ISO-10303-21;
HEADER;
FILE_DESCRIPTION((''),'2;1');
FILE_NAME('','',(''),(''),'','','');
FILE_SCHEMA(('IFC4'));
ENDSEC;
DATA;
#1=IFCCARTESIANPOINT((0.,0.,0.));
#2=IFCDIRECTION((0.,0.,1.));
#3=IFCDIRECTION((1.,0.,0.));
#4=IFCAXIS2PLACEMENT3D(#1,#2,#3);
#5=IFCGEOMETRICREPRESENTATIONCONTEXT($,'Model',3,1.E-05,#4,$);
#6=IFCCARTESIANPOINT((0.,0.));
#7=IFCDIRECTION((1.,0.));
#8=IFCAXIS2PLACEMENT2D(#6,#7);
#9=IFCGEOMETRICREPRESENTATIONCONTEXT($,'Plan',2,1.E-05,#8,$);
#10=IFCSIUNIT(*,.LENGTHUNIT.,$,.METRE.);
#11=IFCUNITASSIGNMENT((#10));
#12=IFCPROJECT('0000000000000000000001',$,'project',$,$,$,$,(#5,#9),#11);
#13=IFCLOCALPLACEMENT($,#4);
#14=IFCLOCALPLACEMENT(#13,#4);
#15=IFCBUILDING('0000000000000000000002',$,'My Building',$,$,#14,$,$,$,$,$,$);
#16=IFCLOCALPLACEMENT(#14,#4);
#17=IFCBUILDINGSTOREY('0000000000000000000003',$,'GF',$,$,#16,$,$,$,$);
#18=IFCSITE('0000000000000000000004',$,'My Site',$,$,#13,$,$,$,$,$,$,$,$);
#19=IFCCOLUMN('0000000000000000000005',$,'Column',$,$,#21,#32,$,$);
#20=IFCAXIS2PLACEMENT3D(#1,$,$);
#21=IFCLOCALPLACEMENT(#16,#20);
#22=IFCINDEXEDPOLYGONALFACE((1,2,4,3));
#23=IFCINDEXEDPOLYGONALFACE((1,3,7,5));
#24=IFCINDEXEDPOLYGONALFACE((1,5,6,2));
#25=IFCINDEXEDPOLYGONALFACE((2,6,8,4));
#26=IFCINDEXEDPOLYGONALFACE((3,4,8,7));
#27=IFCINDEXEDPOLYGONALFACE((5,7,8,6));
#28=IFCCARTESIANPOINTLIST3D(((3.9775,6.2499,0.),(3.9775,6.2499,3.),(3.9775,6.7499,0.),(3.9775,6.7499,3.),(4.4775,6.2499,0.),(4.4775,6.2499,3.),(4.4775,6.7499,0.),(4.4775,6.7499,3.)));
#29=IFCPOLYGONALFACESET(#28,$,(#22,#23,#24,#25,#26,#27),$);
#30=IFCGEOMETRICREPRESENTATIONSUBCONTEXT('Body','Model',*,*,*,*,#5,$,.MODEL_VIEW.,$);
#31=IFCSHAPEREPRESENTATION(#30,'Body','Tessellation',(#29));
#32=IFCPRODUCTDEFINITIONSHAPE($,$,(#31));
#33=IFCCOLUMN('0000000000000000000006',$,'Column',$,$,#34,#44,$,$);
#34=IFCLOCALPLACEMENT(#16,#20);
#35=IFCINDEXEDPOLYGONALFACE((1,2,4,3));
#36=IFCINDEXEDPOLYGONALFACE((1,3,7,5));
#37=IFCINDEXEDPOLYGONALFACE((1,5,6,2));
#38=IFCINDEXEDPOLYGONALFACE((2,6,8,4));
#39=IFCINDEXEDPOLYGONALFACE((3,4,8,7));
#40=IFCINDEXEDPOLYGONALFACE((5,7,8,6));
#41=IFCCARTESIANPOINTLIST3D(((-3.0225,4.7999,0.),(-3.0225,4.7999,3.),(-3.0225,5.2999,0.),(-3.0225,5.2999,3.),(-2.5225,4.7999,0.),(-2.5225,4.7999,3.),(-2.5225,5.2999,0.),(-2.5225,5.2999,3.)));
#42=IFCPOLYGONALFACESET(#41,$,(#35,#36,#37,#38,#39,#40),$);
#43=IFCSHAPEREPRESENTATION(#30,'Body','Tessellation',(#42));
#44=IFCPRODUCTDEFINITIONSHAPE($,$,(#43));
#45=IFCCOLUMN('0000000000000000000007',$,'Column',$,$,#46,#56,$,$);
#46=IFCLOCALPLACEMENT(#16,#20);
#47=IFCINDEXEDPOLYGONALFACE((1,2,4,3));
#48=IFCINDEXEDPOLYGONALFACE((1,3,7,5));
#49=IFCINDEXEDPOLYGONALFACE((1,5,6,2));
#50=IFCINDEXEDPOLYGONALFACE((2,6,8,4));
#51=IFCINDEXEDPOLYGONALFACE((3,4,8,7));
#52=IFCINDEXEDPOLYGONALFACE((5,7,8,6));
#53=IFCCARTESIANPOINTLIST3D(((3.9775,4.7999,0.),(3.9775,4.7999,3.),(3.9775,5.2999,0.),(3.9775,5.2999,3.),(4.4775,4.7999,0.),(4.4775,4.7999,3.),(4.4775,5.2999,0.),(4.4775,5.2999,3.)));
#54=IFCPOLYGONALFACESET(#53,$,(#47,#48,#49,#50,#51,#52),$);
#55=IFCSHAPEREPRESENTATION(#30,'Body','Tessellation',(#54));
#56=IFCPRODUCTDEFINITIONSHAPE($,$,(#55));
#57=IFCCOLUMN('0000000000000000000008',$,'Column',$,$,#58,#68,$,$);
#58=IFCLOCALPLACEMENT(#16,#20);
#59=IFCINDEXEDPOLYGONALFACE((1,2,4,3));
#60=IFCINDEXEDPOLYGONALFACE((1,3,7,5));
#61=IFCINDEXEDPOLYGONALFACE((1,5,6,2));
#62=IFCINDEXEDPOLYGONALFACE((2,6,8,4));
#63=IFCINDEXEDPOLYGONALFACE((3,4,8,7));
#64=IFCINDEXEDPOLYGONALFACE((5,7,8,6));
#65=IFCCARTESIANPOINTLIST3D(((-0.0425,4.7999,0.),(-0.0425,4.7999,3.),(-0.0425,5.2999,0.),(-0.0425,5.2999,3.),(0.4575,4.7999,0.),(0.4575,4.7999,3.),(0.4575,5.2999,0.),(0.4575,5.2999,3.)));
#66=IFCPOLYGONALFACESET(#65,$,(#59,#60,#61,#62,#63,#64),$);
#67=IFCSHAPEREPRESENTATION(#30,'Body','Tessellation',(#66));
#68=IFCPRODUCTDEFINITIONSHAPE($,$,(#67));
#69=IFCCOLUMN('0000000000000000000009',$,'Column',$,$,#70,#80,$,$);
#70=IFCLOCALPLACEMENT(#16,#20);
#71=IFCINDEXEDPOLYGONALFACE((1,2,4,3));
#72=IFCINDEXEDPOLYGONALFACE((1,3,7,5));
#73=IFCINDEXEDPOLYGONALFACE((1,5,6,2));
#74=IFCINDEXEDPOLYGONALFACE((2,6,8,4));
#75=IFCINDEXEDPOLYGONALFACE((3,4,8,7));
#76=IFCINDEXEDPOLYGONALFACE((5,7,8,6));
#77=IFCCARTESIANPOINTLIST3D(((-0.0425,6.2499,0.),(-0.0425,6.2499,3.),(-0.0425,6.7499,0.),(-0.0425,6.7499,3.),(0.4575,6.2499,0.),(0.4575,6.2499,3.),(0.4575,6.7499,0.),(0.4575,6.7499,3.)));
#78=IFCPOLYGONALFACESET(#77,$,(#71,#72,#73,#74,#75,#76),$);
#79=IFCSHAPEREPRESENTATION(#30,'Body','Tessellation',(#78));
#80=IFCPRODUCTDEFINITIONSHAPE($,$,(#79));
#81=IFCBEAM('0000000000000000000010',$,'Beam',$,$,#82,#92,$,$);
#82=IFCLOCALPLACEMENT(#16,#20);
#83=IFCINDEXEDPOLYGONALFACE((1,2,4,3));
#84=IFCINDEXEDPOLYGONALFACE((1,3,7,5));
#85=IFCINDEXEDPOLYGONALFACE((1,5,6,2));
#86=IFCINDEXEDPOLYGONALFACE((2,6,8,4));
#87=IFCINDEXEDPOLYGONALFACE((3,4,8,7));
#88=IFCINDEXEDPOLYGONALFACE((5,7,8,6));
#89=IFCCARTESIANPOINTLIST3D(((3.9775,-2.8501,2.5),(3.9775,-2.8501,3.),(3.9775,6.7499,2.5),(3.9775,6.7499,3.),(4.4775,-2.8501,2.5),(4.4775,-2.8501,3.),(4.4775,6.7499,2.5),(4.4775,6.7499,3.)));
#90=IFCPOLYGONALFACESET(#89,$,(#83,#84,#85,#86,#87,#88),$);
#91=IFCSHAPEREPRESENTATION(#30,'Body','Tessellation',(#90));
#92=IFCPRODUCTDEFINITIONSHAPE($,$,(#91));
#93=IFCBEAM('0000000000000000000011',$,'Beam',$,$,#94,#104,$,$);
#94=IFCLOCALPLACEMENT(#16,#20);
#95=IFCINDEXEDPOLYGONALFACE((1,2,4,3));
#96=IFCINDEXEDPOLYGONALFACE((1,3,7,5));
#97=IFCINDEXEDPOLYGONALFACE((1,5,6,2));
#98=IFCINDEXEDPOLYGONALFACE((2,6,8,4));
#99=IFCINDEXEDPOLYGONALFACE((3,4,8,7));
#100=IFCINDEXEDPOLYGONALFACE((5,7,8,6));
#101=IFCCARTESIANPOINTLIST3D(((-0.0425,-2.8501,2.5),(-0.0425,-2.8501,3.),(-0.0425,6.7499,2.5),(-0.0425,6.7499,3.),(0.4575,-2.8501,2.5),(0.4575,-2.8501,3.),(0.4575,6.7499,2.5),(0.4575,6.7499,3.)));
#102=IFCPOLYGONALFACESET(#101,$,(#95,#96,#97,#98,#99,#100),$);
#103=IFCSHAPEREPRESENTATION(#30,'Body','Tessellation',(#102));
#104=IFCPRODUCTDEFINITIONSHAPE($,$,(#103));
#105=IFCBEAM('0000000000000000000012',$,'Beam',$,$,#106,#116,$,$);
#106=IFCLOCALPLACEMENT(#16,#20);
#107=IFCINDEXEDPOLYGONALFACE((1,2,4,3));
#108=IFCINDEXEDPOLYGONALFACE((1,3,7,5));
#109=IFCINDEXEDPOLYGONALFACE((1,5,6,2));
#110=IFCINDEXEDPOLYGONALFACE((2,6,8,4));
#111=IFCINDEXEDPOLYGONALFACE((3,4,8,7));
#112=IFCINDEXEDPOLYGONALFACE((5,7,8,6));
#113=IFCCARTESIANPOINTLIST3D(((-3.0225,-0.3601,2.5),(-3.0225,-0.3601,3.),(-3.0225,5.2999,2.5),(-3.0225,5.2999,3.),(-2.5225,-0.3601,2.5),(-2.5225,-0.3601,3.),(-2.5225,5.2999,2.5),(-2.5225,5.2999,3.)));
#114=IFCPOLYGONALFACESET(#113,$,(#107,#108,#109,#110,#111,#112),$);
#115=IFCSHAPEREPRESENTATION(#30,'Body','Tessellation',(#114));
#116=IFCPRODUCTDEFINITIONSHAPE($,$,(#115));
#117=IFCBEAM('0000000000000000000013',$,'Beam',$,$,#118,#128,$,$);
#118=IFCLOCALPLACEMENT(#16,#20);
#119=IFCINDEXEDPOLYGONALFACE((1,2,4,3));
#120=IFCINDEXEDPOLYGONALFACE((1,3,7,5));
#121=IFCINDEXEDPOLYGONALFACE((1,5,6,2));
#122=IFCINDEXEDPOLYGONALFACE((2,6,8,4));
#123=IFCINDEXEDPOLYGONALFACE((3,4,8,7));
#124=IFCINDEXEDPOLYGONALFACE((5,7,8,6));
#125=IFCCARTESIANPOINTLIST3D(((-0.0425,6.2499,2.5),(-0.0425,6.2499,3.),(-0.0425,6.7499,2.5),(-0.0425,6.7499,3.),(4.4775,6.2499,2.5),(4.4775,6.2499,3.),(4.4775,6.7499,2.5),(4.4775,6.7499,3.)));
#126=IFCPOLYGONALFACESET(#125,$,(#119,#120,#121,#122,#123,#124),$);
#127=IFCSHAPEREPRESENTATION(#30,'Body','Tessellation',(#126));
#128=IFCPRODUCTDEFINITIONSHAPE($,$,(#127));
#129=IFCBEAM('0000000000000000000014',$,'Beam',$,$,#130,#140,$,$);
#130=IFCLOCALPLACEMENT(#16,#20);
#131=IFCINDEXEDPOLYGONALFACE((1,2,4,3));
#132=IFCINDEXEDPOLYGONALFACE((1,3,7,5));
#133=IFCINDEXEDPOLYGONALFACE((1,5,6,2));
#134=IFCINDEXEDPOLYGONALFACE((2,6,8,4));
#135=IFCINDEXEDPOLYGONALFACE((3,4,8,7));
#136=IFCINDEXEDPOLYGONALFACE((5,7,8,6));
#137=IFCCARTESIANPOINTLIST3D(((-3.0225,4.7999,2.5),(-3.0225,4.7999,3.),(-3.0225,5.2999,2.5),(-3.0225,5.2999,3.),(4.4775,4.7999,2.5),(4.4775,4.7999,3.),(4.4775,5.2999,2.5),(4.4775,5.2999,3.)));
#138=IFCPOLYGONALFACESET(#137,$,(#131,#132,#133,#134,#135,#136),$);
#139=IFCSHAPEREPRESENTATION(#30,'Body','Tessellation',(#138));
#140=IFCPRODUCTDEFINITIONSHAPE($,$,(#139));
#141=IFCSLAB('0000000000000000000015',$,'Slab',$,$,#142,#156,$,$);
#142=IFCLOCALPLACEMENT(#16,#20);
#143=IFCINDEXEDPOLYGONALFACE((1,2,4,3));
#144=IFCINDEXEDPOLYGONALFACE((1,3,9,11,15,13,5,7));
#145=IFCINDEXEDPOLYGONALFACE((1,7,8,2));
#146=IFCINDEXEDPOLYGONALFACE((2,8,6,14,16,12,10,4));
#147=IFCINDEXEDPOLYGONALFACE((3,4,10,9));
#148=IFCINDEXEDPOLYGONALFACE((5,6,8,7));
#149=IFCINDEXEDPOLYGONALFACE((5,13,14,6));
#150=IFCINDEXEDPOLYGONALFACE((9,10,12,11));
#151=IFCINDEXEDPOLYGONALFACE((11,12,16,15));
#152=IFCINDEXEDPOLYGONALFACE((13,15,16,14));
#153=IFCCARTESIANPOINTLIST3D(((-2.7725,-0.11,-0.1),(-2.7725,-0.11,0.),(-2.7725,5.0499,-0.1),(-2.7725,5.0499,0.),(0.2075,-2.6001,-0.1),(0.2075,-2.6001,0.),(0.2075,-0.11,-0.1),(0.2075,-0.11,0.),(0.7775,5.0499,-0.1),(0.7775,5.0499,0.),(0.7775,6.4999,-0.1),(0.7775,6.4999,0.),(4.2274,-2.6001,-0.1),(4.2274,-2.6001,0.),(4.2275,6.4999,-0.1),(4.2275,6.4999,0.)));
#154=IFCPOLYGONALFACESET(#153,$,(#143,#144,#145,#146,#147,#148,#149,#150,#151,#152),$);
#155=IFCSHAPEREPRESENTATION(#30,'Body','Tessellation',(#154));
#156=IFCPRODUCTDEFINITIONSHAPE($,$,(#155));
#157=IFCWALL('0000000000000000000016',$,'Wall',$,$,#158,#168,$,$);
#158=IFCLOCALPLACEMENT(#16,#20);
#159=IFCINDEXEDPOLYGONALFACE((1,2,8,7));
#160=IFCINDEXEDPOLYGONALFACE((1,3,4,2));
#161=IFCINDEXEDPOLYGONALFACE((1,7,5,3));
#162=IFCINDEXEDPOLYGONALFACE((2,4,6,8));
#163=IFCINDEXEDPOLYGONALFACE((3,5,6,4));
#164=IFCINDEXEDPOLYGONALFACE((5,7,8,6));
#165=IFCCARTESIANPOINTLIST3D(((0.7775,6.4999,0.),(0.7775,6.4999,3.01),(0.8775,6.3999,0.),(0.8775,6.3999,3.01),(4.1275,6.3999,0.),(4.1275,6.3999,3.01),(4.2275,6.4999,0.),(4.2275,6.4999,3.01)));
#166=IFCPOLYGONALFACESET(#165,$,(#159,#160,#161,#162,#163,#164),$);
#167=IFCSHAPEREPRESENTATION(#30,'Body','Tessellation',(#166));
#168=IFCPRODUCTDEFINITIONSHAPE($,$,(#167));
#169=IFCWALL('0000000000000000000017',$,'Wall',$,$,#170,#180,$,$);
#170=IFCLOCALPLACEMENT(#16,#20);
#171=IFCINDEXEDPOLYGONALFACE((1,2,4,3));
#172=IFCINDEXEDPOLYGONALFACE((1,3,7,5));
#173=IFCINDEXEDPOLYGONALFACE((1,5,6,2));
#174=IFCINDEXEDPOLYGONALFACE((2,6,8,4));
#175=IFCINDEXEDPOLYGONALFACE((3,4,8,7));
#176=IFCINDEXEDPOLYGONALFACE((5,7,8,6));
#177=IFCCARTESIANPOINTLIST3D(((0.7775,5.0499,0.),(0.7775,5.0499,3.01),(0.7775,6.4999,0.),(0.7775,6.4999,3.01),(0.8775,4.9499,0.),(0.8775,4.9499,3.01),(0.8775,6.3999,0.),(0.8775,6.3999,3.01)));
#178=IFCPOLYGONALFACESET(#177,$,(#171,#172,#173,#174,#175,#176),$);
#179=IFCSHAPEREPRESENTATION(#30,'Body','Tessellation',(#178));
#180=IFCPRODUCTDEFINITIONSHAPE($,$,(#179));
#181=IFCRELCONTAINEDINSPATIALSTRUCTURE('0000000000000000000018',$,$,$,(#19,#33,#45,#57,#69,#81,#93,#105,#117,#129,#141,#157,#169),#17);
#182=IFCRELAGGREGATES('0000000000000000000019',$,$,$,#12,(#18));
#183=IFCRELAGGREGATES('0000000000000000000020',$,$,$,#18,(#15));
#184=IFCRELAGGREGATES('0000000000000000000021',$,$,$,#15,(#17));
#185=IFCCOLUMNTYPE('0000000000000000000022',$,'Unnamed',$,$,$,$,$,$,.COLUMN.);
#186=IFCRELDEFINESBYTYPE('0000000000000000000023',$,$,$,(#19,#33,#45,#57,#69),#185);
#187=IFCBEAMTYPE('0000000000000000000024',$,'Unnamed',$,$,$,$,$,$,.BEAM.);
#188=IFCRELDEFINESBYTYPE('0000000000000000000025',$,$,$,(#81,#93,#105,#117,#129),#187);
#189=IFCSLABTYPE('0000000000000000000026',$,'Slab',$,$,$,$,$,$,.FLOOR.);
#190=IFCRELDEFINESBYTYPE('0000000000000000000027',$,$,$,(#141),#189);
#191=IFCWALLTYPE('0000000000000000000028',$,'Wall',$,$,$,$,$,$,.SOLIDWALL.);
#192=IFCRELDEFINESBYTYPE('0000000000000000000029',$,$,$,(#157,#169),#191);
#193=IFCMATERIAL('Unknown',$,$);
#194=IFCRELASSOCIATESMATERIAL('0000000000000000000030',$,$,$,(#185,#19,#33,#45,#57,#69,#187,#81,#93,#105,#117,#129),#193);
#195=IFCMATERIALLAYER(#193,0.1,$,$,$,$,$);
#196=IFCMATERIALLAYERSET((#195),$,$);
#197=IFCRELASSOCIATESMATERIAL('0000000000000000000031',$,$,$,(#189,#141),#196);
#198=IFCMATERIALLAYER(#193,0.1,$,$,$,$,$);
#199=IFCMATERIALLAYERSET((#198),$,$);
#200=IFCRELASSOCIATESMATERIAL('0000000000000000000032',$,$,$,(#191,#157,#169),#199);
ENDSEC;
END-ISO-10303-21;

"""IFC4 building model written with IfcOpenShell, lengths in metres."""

from ifc_helpers import new_model, si_unit, frame, origin_with_axes, origin_2d_with_axis, place, context, subcontext, project, spatial, line, indexed_curve, rectangle, outline, extrude, material, layer, layer_set, layer_usage, material_profile, profile_set, profile_usage, type_object, element, save


model = new_model("IFC4")

# Units and contexts
model_context = context("Model", 3, precision=1e-05, world=origin_with_axes())
plan_context = context("Plan", 2, precision=1e-05, world=origin_2d_with_axis())
body_context_1 = subcontext(model_context, "Body", "Model", "MODEL_VIEW")
ifc_project = project(units=[si_unit("LENGTHUNIT", "METRE")], contexts=[model_context, plan_context])

# Site, building, storey
site_placement = place(None, origin_with_axes())
site = spatial("IfcSite", under=ifc_project, at=site_placement, Name="My Site")
building_placement = place(site_placement, origin_with_axes())
building = spatial("IfcBuilding", under=site, at=building_placement, Name="My Building")
storey_placement = place(building_placement, origin_with_axes())
storey = spatial("IfcBuildingStorey", under=building, at=storey_placement, Name="GF")

# Columns
ifc_material_1 = material(Name="Unknown")
ifc_material_profile_1 = material_profile(ifc_material_1, rectangle(XDim=0.5, YDim=0.5))
ifc_profile_set_1 = profile_set([ifc_material_profile_1])
ifc_profile_usage_1 = profile_usage(ifc_profile_set_1, cardinal=5)
column_type = type_object("IfcColumnType", Name="Unnamed", PredefinedType="COLUMN", material=ifc_profile_set_1)
column_1_placement = place(storey_placement, frame((4.2275, 6.4999, 0.0), z_axis=(0.0, 0.0, 1.0), x_axis=(1.0, 0.0, 0.0)))
element("IfcColumn", 1, at=column_1_placement, inside=storey, type_object=column_type, material=ifc_profile_usage_1, Name="Column", context=body_context_1, shape_type="SweptSolid", body=[
    extrude(rectangle(XDim=0.5, YDim=0.5), origin_with_axes(), (0.0, 0.0, 1.0), 3.0),
])
ifc_profile_usage_2 = profile_usage(ifc_profile_set_1, cardinal=5)
column_2_placement = place(storey_placement, frame((-2.7725, 5.0499, 0.0), z_axis=(0.0, 0.0, 1.0), x_axis=(1.0, 0.0, 0.0)))
element("IfcColumn", 2, at=column_2_placement, inside=storey, type_object=column_type, material=ifc_profile_usage_2, Name="Column", context=body_context_1, shape_type="SweptSolid", body=[
    extrude(rectangle(XDim=0.5, YDim=0.5), origin_with_axes(), (0.0, 0.0, 1.0), 3.0),
])
ifc_profile_usage_3 = profile_usage(ifc_profile_set_1, cardinal=5)
column_3_placement = place(storey_placement, frame((4.2275, 5.0499, 0.0), z_axis=(0.0, 0.0, 1.0), x_axis=(1.0, 0.0, 0.0)))
element("IfcColumn", 3, at=column_3_placement, inside=storey, type_object=column_type, material=ifc_profile_usage_3, Name="Column", context=body_context_1, shape_type="SweptSolid", body=[
    extrude(rectangle(XDim=0.5, YDim=0.5), origin_with_axes(), (0.0, 0.0, 1.0), 3.0),
])
ifc_profile_usage_4 = profile_usage(ifc_profile_set_1, cardinal=5)
column_4_placement = place(storey_placement, frame((0.2075, 5.0499, 0.0), z_axis=(0.0, 0.0, 1.0), x_axis=(1.0, 0.0, 0.0)))
element("IfcColumn", 4, at=column_4_placement, inside=storey, type_object=column_type, material=ifc_profile_usage_4, Name="Column", context=body_context_1, shape_type="SweptSolid", body=[
    extrude(rectangle(XDim=0.5, YDim=0.5), origin_with_axes(), (0.0, 0.0, 1.0), 3.0),
])
ifc_profile_usage_5 = profile_usage(ifc_profile_set_1, cardinal=5)
column_5_placement = place(storey_placement, frame((0.2075, 6.4999, 0.0), z_axis=(0.0, 0.0, 1.0), x_axis=(1.0, 0.0, 0.0)))
element("IfcColumn", 5, at=column_5_placement, inside=storey, type_object=column_type, material=ifc_profile_usage_5, Name="Column", context=body_context_1, shape_type="SweptSolid", body=[
    extrude(rectangle(XDim=0.5, YDim=0.5), origin_with_axes(), (0.0, 0.0, 1.0), 3.0),
])

# Beams
ifc_material_profile_2 = material_profile(ifc_material_1, rectangle(XDim=0.5, YDim=0.5))
ifc_profile_set_2 = profile_set([ifc_material_profile_2])
ifc_profile_usage_6 = profile_usage(ifc_profile_set_2, cardinal=7)
beam_type = type_object("IfcBeamType", Name="Unnamed", PredefinedType="BEAM", material=ifc_profile_set_2)
beam_1_placement = place(storey_placement, frame((4.4775, 6.7499, 3.0), z_axis=(0.0, -1.0, 0.0), x_axis=(1.0, 0.0, 0.0)))
element("IfcBeam", 6, at=beam_1_placement, inside=storey, type_object=beam_type, material=ifc_profile_usage_6, Name="Beam", context=body_context_1, shape_type="SweptSolid", body=[
    extrude(rectangle(XDim=0.5, YDim=0.5), frame((-0.25, -0.25, 0.0), z_axis=(0.0, 0.0, 1.0), x_axis=(1.0, 0.0, 0.0)), (0.0, 0.0, 1.0), 9.6),
])
ifc_profile_usage_7 = profile_usage(ifc_profile_set_2, cardinal=7)
beam_2_placement = place(storey_placement, frame((0.4575, 6.7499, 3.0), z_axis=(0.0, -1.0, 0.0), x_axis=(1.0, 0.0, 0.0)))
element("IfcBeam", 7, at=beam_2_placement, inside=storey, type_object=beam_type, material=ifc_profile_usage_7, Name="Beam", context=body_context_1, shape_type="SweptSolid", body=[
    extrude(rectangle(XDim=0.5, YDim=0.5), frame((-0.25, -0.25, 0.0), z_axis=(0.0, 0.0, 1.0), x_axis=(1.0, 0.0, 0.0)), (0.0, 0.0, 1.0), 9.6),
])
ifc_profile_usage_8 = profile_usage(ifc_profile_set_2, cardinal=7)
beam_3_placement = place(storey_placement, frame((-2.5225, 5.2999, 3.0), z_axis=(0.0, -1.0, 0.0), x_axis=(1.0, 0.0, 0.0)))
element("IfcBeam", 8, at=beam_3_placement, inside=storey, type_object=beam_type, material=ifc_profile_usage_8, Name="Beam", context=body_context_1, shape_type="SweptSolid", body=[
    extrude(rectangle(XDim=0.5, YDim=0.5), frame((-0.25, -0.25, 0.0), z_axis=(0.0, 0.0, 1.0), x_axis=(1.0, 0.0, 0.0)), (0.0, 0.0, 1.0), 5.66),
])
ifc_profile_usage_9 = profile_usage(ifc_profile_set_2, cardinal=7)
beam_4_placement = place(storey_placement, frame((4.4775, 6.2499, 3.0), z_axis=(-1.0, 0.0, 0.0), x_axis=(0.0, -1.0, 0.0)))
element("IfcBeam", 9, at=beam_4_placement, inside=storey, type_object=beam_type, material=ifc_profile_usage_9, Name="Beam", context=body_context_1, shape_type="SweptSolid", body=[
    extrude(rectangle(XDim=0.5, YDim=0.5), frame((-0.25, -0.25, 0.0), z_axis=(0.0, 0.0, 1.0), x_axis=(1.0, 0.0, 0.0)), (0.0, 0.0, 1.0), 4.52),
])
ifc_profile_usage_10 = profile_usage(ifc_profile_set_2, cardinal=7)
beam_5_placement = place(storey_placement, frame((4.4775, 4.7999, 3.0), z_axis=(-1.0, 0.0, 0.0), x_axis=(0.0, -1.0, 0.0)))
element("IfcBeam", 10, at=beam_5_placement, inside=storey, type_object=beam_type, material=ifc_profile_usage_10, Name="Beam", context=body_context_1, shape_type="SweptSolid", body=[
    extrude(rectangle(XDim=0.5, YDim=0.5), frame((-0.25, -0.25, 0.0), z_axis=(0.0, 0.0, 1.0), x_axis=(1.0, 0.0, 0.0)), (0.0, 0.0, 1.0), 7.5),
])

# Slab
ifc_layer_1 = layer(ifc_material_1, 0.1)
ifc_layer_set_1 = layer_set([ifc_layer_1])
ifc_layer_usage_1 = layer_usage(ifc_layer_set_1, "AXIS3", "POSITIVE", -0.1)
slab_type = type_object("IfcSlabType", Name="Slab", PredefinedType="FLOOR", material=ifc_layer_set_1)
slab_placement = place(storey_placement, frame((4.2275, 6.4999, 0.0), z_axis=(0.0, 0.0, 1.0), x_axis=(1.0, 0.0, 0.0)))
element("IfcSlab", 11, at=slab_placement, inside=storey, type_object=slab_type, material=ifc_layer_usage_1, Name="Slab", context=body_context_1, shape_type="SweptSolid", body=[
    extrude(outline(indexed_curve([(0.0, 0.0), (-3.45, 0.0), (-3.45, -1.45), (-7.0, -1.45), (-7.0, -6.61), (-4.02, -6.61), (-4.02, -9.1), (-0.0001, -9.1), (0.0, 0.0)])), frame((0.0, 0.0, -0.1), z_axis=(0.0, 0.0, 1.0), x_axis=(1.0, 0.0, 0.0)), (0.0, 0.0, 1.0), 0.1),
])

# Walls
ifc_layer_2 = layer(ifc_material_1, 0.1)
ifc_layer_set_2 = layer_set([ifc_layer_2])
ifc_layer_usage_2 = layer_usage(ifc_layer_set_2, "AXIS2", "POSITIVE", 0.0)
wall_type = type_object("IfcWallType", Name="Wall", PredefinedType="SOLIDWALL", material=ifc_layer_set_2)
wall_1_placement = place(storey_placement, frame((4.2275, 6.4999, 0.0), z_axis=(0.0, 0.0, 1.0), x_axis=(-1.0, 0.0, 0.0)))
element("IfcWall", 12, at=wall_1_placement, inside=storey, type_object=wall_type, material=ifc_layer_usage_2, Name="Wall", context=body_context_1, shape_type="SweptSolid", body=[
    extrude(outline(indexed_curve([(0.0, 0.0), (0.1, 0.1), (3.35, 0.1), (3.45, 0.0)], segments=[line(1, 2, 3, 4, 1)])), origin_with_axes(), (0.0, 0.0, 1.0), 3.01),
])
ifc_layer_usage_3 = layer_usage(ifc_layer_set_2, "AXIS2", "POSITIVE", 0.0)
wall_2_placement = place(storey_placement, frame((0.7775, 6.4999, 0.0), z_axis=(0.0, 0.0, 1.0), x_axis=(0.0, -1.0, 0.0)))
element("IfcWall", 13, at=wall_2_placement, inside=storey, type_object=wall_type, material=ifc_layer_usage_3, Name="Wall", context=body_context_1, shape_type="SweptSolid", body=[
    extrude(outline(indexed_curve([(0.0, 0.0), (0.1, 0.1), (1.55, 0.1), (1.45, 0.0)], segments=[line(1, 2, 3, 4, 1)])), origin_with_axes(), (0.0, 0.0, 1.0), 3.01),
])

save(model, "model.ifc")
